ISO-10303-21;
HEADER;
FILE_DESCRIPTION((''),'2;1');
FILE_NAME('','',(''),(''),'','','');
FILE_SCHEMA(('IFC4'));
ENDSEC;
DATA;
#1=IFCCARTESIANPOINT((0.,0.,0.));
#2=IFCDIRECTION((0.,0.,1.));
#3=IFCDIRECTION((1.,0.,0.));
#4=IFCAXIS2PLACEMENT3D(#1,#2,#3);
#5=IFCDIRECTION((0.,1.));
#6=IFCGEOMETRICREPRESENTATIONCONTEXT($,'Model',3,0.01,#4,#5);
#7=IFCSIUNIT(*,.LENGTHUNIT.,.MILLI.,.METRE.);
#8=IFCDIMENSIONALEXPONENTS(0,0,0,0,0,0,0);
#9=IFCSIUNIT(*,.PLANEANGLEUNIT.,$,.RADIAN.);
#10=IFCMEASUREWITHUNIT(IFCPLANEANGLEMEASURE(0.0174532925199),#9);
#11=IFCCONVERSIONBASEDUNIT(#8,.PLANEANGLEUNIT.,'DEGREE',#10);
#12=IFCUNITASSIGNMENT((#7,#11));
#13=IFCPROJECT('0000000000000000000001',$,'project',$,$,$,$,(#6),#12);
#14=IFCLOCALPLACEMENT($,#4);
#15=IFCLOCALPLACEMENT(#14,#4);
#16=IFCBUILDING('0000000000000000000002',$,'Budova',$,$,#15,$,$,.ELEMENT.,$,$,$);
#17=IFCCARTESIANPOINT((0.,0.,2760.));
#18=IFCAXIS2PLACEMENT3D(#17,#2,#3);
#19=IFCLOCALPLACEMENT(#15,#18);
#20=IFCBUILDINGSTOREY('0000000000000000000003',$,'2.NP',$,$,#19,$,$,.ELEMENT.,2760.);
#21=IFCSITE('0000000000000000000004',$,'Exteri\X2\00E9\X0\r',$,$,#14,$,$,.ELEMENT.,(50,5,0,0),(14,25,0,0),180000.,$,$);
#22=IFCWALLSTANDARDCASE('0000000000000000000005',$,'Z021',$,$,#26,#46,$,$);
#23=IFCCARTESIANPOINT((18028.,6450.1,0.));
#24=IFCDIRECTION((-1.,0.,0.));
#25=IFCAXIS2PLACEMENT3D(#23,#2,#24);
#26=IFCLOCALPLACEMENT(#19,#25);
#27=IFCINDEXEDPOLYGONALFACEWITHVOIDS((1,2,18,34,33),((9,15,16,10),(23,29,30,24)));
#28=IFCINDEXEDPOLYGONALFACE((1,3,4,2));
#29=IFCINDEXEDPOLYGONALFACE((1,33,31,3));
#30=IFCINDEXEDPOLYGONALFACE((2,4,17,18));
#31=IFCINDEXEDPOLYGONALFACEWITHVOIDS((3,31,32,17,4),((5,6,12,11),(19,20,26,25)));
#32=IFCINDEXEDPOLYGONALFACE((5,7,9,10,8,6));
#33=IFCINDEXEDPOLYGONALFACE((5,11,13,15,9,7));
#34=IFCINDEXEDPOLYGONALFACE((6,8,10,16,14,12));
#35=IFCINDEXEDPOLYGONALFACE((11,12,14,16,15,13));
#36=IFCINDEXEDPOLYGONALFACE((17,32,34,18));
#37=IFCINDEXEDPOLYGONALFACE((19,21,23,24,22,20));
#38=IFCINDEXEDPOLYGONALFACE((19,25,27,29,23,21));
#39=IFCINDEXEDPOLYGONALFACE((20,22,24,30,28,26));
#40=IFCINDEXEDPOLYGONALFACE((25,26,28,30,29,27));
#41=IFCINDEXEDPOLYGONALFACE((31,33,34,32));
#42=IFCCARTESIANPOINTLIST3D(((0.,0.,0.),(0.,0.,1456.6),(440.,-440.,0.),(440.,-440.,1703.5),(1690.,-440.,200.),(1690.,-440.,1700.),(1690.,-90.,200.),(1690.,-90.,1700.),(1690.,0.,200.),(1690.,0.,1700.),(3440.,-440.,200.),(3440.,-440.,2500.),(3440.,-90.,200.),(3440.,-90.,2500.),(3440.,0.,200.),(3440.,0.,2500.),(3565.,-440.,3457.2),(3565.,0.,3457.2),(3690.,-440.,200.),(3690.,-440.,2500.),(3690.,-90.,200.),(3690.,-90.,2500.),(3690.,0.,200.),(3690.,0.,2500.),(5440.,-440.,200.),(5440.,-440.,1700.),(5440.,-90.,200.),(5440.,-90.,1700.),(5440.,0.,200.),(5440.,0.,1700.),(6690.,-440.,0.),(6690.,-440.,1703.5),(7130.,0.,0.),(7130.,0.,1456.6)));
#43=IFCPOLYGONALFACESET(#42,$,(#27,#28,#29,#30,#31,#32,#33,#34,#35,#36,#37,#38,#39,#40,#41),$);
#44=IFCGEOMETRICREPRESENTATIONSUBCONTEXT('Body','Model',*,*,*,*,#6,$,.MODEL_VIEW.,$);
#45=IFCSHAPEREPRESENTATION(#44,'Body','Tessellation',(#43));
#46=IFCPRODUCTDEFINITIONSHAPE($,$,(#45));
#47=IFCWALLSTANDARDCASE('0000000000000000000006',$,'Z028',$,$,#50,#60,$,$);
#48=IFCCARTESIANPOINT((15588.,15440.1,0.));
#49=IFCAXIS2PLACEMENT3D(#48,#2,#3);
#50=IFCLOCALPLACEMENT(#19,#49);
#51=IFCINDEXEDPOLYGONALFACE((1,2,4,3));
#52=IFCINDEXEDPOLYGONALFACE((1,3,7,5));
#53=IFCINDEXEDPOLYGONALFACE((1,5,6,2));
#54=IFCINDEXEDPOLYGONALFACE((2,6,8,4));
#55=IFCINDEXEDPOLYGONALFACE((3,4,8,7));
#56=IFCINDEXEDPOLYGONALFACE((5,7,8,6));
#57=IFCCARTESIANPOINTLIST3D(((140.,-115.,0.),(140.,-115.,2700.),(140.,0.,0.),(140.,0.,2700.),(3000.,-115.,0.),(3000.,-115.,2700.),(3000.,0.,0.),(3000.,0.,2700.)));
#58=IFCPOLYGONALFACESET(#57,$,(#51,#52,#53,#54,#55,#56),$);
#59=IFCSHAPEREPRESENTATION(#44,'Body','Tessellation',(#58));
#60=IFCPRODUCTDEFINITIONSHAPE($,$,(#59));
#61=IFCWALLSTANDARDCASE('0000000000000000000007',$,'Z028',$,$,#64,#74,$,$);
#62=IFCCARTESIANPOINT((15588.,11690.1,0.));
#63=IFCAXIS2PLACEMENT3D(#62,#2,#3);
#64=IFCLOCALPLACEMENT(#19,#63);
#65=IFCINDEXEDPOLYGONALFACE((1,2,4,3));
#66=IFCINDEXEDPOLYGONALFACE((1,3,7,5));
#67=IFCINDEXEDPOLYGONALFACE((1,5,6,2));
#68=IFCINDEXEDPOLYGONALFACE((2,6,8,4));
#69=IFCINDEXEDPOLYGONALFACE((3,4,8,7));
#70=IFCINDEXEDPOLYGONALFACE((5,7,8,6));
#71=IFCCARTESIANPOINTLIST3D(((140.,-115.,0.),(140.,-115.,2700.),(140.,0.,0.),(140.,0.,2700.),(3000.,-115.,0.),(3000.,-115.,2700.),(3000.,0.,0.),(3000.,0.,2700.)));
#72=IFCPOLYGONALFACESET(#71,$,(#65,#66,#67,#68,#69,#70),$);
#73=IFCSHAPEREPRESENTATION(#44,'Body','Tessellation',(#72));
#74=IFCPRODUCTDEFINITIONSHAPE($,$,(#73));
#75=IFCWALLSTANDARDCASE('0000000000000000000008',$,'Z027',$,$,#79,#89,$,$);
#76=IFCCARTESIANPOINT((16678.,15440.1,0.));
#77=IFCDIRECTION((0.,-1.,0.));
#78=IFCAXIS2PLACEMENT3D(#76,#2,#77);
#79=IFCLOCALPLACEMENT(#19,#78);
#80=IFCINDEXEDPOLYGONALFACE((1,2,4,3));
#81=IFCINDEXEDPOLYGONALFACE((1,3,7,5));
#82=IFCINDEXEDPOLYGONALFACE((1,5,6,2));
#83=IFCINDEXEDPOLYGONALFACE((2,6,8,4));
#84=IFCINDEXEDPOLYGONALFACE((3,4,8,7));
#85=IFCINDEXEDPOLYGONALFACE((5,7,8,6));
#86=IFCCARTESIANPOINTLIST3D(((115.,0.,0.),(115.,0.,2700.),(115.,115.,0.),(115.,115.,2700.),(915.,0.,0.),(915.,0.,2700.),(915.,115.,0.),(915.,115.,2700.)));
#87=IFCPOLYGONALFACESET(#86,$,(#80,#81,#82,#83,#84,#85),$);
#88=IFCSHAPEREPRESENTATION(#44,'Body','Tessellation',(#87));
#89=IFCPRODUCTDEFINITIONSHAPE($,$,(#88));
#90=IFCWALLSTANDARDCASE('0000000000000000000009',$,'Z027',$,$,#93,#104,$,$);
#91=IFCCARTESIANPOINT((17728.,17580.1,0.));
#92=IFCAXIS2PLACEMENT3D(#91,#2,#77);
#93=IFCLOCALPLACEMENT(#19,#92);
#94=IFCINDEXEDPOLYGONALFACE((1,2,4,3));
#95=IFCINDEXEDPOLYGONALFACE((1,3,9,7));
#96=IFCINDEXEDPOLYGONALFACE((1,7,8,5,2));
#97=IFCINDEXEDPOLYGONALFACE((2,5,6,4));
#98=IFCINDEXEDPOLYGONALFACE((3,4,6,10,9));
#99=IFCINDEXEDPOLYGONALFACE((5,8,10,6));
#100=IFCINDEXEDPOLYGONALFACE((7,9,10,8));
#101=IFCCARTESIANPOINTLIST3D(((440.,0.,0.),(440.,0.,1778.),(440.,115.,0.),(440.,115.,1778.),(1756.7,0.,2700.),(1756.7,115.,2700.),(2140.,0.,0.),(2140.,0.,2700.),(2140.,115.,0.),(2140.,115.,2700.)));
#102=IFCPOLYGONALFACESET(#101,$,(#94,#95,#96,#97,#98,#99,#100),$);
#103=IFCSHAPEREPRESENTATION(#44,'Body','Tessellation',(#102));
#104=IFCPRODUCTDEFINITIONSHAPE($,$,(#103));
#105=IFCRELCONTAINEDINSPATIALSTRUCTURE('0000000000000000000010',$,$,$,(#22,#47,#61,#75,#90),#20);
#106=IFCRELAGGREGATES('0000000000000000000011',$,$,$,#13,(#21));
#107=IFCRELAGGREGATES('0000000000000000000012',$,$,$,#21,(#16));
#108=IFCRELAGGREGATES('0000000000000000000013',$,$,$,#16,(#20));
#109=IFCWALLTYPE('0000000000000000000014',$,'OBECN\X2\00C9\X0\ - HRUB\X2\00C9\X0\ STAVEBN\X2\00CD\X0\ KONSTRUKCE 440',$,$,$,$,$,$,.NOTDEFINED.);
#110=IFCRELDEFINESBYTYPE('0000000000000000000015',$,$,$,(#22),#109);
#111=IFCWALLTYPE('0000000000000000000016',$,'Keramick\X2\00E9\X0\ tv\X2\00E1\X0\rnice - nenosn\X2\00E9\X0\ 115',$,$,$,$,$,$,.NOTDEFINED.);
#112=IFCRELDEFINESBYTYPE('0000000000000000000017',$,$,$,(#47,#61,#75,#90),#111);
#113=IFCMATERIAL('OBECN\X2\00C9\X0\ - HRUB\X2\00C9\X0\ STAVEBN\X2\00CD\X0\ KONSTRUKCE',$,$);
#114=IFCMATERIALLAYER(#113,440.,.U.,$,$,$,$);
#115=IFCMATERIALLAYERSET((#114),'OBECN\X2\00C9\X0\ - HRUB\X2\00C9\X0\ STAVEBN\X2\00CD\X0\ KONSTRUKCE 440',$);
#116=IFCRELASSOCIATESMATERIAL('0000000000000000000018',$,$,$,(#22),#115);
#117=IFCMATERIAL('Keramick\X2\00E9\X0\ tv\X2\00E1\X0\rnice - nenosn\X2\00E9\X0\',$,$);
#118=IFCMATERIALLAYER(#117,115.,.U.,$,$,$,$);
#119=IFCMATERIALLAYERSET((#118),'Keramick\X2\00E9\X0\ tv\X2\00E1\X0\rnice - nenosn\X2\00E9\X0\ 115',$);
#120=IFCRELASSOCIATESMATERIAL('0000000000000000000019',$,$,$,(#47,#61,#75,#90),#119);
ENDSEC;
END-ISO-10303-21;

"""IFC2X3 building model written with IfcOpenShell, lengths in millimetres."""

from ifc_helpers import new_model, entity, si_unit, converted_unit, direction, frame, origin_with_axes, place, context, subcontext, project, spatial, polyline, outline, extrude, clip, halfspace, bounded_halfspace, material, layer, layer_set, layer_usage, type_object, element, save


model = new_model("IFC2X3")

# Units and contexts
model_context = context("Model", 3, precision=0.01, world=origin_with_axes(), true_north=direction((0.0, 1.0)))
body_context = subcontext(model_context, "Body", "Model", "MODEL_VIEW")
ifc_project = project(units=[si_unit("LENGTHUNIT", "METRE", prefix="MILLI"), converted_unit("PLANEANGLEUNIT", "DEGREE", entity("IfcPlaneAngleMeasure", 0.0174532925199), si_unit("PLANEANGLEUNIT", "RADIAN"), dimensions=[0, 0, 0, 0, 0, 0, 0])], contexts=[model_context])

# Site, building, storey
site_placement = place(None, origin_with_axes())
site = spatial("IfcSite", under=ifc_project, at=site_placement, Name="Exteriér", CompositionType="ELEMENT", RefLatitude=(50, 5, 0, 0), RefLongitude=(14, 25, 0, 0), RefElevation=180000.0)
building_placement = place(site_placement, origin_with_axes())
building = spatial("IfcBuilding", under=site, at=building_placement, Name="Budova", CompositionType="ELEMENT")
storey_placement = place(building_placement, frame((0.0, 0.0, 2760.0), z_axis=(0.0, 0.0, 1.0), x_axis=(1.0, 0.0, 0.0)))
storey = spatial("IfcBuildingStorey", under=building, at=storey_placement, Name="2.NP", CompositionType="ELEMENT", Elevation=2760.0)

# Shared definitions
ifc_material_1 = material(Name="OBECNÉ - HRUBÉ STAVEBNÍ KONSTRUKCE")
ifc_layer_1 = layer(ifc_material_1, 440.0, ventilated="UNKNOWN")
ifc_layer_set_1 = layer_set([ifc_layer_1], Name="OBECNÉ - HRUBÉ STAVEBNÍ KONSTRUKCE 440")
wall_type_1 = type_object("IfcWallType", Name="OBECNÉ - HRUBÉ STAVEBNÍ KONSTRUKCE 440", PredefinedType="NOTDEFINED")

# Wall, openings
ifc_layer_usage_1 = layer_usage(ifc_layer_set_1, "AXIS2", "POSITIVE", -440.0)
wall_1_placement = place(storey_placement, frame((18028.0, 6450.1, 0.0), z_axis=(0.0, 0.0, 1.0), x_axis=(-1.0, 0.0, 0.0)))
wall_1 = element("IfcWallStandardCase", 1, at=wall_1_placement, inside=storey, type_object=wall_type_1, material=ifc_layer_usage_1, Name="Z021", context=body_context, shape_type="Clipping", body=[
    clip(clip(extrude(outline(polyline([(440.0, -440.0), (6690.0, -440.0), (7130.0, 0.0), (0.0, 0.0), (440.0, -440.0)])), origin_with_axes(), (0.0, 0.0, 1.0), 6000.0), bounded_halfspace(frame((-621.6, 0.0, 1107.8), z_axis=(0.489382, 0.0, -0.872069), x_axis=(0.0, 1.0, 0.0)), True, origin_with_axes(), polyline([(-479.3, -450.0), (3565.0, -450.0), (3565.0, 10.0), (-479.3, 10.0), (-479.3, -450.0)]))), bounded_halfspace(frame((2329.2, 0.0, 4150.7), z_axis=(-0.489382, 0.0, -0.872069), x_axis=(0.0, 1.0, 0.0)), True, origin_with_axes(), polyline([(3565.0, -450.0), (7609.3, -450.0), (7609.3, 10.0), (3565.0, 10.0), (3565.0, -450.0)]))),
])
opening_1_placement = place(wall_1_placement, frame((2565.0, 0.0, 200.0), z_axis=(0.0, 0.0, 1.0), x_axis=(1.0, 0.0, 0.0)))
element("IfcOpeningElement", 2, at=opening_1_placement, cuts=wall_1, context=body_context, shape_type="SweptSolid", body=[
    extrude(outline(polyline([(875.0, 0.0), (875.0, 1500.0), (-875.0, 2300.0), (-875.0, 0.0), (875.0, 0.0)])), frame((0.0, -90.0, 0.0), z_axis=(0.0, 1.0, 0.0), x_axis=(-1.0, 0.0, 0.0)), (0.0, 0.0, -1.0), 790.0),
    extrude(outline(polyline([(-875.0, 0.0), (-875.0, -2300.0), (875.0, -1500.0), (875.0, 0.0), (-875.0, 0.0)])), frame((0.0, -90.0, 0.0), z_axis=(0.0, -1.0, 0.0), x_axis=(-1.0, 0.0, 0.0)), (0.0, 0.0, -1.0), 530.0),
])
opening_2_placement = place(wall_1_placement, frame((4565.0, 0.0, 200.0), z_axis=(0.0, 0.0, 1.0), x_axis=(1.0, 0.0, 0.0)))
element("IfcOpeningElement", 3, at=opening_2_placement, cuts=wall_1, context=body_context, shape_type="SweptSolid", body=[
    extrude(outline(polyline([(875.0, 0.0), (875.0, 1500.0), (-875.0, 2300.0), (-875.0, 0.0), (875.0, 0.0)])), frame((0.0, -90.0, 0.0), z_axis=(0.0, -1.0, 0.0), x_axis=(1.0, 0.0, 0.0)), (0.0, 0.0, 1.0), 790.0),
    extrude(outline(polyline([(-875.0, 0.0), (-875.0, -2300.0), (875.0, -1500.0), (875.0, 0.0), (-875.0, 0.0)])), frame((0.0, -90.0, 0.0), z_axis=(0.0, 1.0, 0.0), x_axis=(1.0, 0.0, 0.0)), (0.0, 0.0, 1.0), 530.0),
])

# Walls
ifc_material_2 = material(Name="Keramické tvárnice - nenosné")
ifc_layer_2 = layer(ifc_material_2, 115.0, ventilated="UNKNOWN")
ifc_layer_set_2 = layer_set([ifc_layer_2], Name="Keramické tvárnice - nenosné 115")
ifc_layer_usage_2 = layer_usage(ifc_layer_set_2, "AXIS2", "POSITIVE", -115.0)
wall_type_2 = type_object("IfcWallType", Name="Keramické tvárnice - nenosné 115", PredefinedType="NOTDEFINED")
wall_2_placement = place(storey_placement, frame((15588.0, 15440.1, 0.0), z_axis=(0.0, 0.0, 1.0), x_axis=(1.0, 0.0, 0.0)))
element("IfcWallStandardCase", 4, at=wall_2_placement, inside=storey, type_object=wall_type_2, material=ifc_layer_usage_2, Name="Z028", context=body_context, shape_type="SweptSolid", body=[
    extrude(outline(polyline([(140.0, -115.0), (3000.0, -115.0), (3000.0, 0.0), (140.0, 0.0), (140.0, -115.0)])), origin_with_axes(), (0.0, 0.0, 1.0), 2700.0),
])
ifc_layer_usage_3 = layer_usage(ifc_layer_set_2, "AXIS2", "POSITIVE", -115.0)
wall_3_placement = place(storey_placement, frame((15588.0, 11690.1, 0.0), z_axis=(0.0, 0.0, 1.0), x_axis=(1.0, 0.0, 0.0)))
element("IfcWallStandardCase", 5, at=wall_3_placement, inside=storey, type_object=wall_type_2, material=ifc_layer_usage_3, Name="Z028", context=body_context, shape_type="SweptSolid", body=[
    extrude(outline(polyline([(140.0, -115.0), (3000.0, -115.0), (3000.0, 0.0), (140.0, 0.0), (140.0, -115.0)])), origin_with_axes(), (0.0, 0.0, 1.0), 2700.0),
])
ifc_layer_usage_4 = layer_usage(ifc_layer_set_2, "AXIS2", "NEGATIVE", 115.0)
wall_4_placement = place(storey_placement, frame((16678.0, 15440.1, 0.0), z_axis=(0.0, 0.0, 1.0), x_axis=(0.0, -1.0, 0.0)))
element("IfcWallStandardCase", 6, at=wall_4_placement, inside=storey, type_object=wall_type_2, material=ifc_layer_usage_4, Name="Z027", context=body_context, shape_type="SweptSolid", body=[
    extrude(outline(polyline([(115.0, 0.0), (915.0, 0.0), (915.0, 115.0), (115.0, 115.0), (115.0, 0.0)])), origin_with_axes(), (0.0, 0.0, 1.0), 2700.0),
])
ifc_layer_usage_5 = layer_usage(ifc_layer_set_2, "AXIS2", "NEGATIVE", 115.0)
wall_5_placement = place(storey_placement, frame((17728.0, 17580.1, 0.0), z_axis=(0.0, 0.0, 1.0), x_axis=(0.0, -1.0, 0.0)))
element("IfcWallStandardCase", 7, at=wall_5_placement, inside=storey, type_object=wall_type_2, material=ifc_layer_usage_5, Name="Z027", context=body_context, shape_type="Clipping", body=[
    clip(extrude(outline(polyline([(440.0, 0.0), (2140.0, 0.0), (2140.0, 115.0), (440.0, 115.0), (440.0, 0.0)])), origin_with_axes(), (0.0, 0.0, 1.0), 2700.0), halfspace(frame((-690.7, 0.0, 986.4), z_axis=(0.573576, 0.0, -0.819152), x_axis=(0.0, 1.0, 0.0)), True)),
])

save(model, "model.ifc")
